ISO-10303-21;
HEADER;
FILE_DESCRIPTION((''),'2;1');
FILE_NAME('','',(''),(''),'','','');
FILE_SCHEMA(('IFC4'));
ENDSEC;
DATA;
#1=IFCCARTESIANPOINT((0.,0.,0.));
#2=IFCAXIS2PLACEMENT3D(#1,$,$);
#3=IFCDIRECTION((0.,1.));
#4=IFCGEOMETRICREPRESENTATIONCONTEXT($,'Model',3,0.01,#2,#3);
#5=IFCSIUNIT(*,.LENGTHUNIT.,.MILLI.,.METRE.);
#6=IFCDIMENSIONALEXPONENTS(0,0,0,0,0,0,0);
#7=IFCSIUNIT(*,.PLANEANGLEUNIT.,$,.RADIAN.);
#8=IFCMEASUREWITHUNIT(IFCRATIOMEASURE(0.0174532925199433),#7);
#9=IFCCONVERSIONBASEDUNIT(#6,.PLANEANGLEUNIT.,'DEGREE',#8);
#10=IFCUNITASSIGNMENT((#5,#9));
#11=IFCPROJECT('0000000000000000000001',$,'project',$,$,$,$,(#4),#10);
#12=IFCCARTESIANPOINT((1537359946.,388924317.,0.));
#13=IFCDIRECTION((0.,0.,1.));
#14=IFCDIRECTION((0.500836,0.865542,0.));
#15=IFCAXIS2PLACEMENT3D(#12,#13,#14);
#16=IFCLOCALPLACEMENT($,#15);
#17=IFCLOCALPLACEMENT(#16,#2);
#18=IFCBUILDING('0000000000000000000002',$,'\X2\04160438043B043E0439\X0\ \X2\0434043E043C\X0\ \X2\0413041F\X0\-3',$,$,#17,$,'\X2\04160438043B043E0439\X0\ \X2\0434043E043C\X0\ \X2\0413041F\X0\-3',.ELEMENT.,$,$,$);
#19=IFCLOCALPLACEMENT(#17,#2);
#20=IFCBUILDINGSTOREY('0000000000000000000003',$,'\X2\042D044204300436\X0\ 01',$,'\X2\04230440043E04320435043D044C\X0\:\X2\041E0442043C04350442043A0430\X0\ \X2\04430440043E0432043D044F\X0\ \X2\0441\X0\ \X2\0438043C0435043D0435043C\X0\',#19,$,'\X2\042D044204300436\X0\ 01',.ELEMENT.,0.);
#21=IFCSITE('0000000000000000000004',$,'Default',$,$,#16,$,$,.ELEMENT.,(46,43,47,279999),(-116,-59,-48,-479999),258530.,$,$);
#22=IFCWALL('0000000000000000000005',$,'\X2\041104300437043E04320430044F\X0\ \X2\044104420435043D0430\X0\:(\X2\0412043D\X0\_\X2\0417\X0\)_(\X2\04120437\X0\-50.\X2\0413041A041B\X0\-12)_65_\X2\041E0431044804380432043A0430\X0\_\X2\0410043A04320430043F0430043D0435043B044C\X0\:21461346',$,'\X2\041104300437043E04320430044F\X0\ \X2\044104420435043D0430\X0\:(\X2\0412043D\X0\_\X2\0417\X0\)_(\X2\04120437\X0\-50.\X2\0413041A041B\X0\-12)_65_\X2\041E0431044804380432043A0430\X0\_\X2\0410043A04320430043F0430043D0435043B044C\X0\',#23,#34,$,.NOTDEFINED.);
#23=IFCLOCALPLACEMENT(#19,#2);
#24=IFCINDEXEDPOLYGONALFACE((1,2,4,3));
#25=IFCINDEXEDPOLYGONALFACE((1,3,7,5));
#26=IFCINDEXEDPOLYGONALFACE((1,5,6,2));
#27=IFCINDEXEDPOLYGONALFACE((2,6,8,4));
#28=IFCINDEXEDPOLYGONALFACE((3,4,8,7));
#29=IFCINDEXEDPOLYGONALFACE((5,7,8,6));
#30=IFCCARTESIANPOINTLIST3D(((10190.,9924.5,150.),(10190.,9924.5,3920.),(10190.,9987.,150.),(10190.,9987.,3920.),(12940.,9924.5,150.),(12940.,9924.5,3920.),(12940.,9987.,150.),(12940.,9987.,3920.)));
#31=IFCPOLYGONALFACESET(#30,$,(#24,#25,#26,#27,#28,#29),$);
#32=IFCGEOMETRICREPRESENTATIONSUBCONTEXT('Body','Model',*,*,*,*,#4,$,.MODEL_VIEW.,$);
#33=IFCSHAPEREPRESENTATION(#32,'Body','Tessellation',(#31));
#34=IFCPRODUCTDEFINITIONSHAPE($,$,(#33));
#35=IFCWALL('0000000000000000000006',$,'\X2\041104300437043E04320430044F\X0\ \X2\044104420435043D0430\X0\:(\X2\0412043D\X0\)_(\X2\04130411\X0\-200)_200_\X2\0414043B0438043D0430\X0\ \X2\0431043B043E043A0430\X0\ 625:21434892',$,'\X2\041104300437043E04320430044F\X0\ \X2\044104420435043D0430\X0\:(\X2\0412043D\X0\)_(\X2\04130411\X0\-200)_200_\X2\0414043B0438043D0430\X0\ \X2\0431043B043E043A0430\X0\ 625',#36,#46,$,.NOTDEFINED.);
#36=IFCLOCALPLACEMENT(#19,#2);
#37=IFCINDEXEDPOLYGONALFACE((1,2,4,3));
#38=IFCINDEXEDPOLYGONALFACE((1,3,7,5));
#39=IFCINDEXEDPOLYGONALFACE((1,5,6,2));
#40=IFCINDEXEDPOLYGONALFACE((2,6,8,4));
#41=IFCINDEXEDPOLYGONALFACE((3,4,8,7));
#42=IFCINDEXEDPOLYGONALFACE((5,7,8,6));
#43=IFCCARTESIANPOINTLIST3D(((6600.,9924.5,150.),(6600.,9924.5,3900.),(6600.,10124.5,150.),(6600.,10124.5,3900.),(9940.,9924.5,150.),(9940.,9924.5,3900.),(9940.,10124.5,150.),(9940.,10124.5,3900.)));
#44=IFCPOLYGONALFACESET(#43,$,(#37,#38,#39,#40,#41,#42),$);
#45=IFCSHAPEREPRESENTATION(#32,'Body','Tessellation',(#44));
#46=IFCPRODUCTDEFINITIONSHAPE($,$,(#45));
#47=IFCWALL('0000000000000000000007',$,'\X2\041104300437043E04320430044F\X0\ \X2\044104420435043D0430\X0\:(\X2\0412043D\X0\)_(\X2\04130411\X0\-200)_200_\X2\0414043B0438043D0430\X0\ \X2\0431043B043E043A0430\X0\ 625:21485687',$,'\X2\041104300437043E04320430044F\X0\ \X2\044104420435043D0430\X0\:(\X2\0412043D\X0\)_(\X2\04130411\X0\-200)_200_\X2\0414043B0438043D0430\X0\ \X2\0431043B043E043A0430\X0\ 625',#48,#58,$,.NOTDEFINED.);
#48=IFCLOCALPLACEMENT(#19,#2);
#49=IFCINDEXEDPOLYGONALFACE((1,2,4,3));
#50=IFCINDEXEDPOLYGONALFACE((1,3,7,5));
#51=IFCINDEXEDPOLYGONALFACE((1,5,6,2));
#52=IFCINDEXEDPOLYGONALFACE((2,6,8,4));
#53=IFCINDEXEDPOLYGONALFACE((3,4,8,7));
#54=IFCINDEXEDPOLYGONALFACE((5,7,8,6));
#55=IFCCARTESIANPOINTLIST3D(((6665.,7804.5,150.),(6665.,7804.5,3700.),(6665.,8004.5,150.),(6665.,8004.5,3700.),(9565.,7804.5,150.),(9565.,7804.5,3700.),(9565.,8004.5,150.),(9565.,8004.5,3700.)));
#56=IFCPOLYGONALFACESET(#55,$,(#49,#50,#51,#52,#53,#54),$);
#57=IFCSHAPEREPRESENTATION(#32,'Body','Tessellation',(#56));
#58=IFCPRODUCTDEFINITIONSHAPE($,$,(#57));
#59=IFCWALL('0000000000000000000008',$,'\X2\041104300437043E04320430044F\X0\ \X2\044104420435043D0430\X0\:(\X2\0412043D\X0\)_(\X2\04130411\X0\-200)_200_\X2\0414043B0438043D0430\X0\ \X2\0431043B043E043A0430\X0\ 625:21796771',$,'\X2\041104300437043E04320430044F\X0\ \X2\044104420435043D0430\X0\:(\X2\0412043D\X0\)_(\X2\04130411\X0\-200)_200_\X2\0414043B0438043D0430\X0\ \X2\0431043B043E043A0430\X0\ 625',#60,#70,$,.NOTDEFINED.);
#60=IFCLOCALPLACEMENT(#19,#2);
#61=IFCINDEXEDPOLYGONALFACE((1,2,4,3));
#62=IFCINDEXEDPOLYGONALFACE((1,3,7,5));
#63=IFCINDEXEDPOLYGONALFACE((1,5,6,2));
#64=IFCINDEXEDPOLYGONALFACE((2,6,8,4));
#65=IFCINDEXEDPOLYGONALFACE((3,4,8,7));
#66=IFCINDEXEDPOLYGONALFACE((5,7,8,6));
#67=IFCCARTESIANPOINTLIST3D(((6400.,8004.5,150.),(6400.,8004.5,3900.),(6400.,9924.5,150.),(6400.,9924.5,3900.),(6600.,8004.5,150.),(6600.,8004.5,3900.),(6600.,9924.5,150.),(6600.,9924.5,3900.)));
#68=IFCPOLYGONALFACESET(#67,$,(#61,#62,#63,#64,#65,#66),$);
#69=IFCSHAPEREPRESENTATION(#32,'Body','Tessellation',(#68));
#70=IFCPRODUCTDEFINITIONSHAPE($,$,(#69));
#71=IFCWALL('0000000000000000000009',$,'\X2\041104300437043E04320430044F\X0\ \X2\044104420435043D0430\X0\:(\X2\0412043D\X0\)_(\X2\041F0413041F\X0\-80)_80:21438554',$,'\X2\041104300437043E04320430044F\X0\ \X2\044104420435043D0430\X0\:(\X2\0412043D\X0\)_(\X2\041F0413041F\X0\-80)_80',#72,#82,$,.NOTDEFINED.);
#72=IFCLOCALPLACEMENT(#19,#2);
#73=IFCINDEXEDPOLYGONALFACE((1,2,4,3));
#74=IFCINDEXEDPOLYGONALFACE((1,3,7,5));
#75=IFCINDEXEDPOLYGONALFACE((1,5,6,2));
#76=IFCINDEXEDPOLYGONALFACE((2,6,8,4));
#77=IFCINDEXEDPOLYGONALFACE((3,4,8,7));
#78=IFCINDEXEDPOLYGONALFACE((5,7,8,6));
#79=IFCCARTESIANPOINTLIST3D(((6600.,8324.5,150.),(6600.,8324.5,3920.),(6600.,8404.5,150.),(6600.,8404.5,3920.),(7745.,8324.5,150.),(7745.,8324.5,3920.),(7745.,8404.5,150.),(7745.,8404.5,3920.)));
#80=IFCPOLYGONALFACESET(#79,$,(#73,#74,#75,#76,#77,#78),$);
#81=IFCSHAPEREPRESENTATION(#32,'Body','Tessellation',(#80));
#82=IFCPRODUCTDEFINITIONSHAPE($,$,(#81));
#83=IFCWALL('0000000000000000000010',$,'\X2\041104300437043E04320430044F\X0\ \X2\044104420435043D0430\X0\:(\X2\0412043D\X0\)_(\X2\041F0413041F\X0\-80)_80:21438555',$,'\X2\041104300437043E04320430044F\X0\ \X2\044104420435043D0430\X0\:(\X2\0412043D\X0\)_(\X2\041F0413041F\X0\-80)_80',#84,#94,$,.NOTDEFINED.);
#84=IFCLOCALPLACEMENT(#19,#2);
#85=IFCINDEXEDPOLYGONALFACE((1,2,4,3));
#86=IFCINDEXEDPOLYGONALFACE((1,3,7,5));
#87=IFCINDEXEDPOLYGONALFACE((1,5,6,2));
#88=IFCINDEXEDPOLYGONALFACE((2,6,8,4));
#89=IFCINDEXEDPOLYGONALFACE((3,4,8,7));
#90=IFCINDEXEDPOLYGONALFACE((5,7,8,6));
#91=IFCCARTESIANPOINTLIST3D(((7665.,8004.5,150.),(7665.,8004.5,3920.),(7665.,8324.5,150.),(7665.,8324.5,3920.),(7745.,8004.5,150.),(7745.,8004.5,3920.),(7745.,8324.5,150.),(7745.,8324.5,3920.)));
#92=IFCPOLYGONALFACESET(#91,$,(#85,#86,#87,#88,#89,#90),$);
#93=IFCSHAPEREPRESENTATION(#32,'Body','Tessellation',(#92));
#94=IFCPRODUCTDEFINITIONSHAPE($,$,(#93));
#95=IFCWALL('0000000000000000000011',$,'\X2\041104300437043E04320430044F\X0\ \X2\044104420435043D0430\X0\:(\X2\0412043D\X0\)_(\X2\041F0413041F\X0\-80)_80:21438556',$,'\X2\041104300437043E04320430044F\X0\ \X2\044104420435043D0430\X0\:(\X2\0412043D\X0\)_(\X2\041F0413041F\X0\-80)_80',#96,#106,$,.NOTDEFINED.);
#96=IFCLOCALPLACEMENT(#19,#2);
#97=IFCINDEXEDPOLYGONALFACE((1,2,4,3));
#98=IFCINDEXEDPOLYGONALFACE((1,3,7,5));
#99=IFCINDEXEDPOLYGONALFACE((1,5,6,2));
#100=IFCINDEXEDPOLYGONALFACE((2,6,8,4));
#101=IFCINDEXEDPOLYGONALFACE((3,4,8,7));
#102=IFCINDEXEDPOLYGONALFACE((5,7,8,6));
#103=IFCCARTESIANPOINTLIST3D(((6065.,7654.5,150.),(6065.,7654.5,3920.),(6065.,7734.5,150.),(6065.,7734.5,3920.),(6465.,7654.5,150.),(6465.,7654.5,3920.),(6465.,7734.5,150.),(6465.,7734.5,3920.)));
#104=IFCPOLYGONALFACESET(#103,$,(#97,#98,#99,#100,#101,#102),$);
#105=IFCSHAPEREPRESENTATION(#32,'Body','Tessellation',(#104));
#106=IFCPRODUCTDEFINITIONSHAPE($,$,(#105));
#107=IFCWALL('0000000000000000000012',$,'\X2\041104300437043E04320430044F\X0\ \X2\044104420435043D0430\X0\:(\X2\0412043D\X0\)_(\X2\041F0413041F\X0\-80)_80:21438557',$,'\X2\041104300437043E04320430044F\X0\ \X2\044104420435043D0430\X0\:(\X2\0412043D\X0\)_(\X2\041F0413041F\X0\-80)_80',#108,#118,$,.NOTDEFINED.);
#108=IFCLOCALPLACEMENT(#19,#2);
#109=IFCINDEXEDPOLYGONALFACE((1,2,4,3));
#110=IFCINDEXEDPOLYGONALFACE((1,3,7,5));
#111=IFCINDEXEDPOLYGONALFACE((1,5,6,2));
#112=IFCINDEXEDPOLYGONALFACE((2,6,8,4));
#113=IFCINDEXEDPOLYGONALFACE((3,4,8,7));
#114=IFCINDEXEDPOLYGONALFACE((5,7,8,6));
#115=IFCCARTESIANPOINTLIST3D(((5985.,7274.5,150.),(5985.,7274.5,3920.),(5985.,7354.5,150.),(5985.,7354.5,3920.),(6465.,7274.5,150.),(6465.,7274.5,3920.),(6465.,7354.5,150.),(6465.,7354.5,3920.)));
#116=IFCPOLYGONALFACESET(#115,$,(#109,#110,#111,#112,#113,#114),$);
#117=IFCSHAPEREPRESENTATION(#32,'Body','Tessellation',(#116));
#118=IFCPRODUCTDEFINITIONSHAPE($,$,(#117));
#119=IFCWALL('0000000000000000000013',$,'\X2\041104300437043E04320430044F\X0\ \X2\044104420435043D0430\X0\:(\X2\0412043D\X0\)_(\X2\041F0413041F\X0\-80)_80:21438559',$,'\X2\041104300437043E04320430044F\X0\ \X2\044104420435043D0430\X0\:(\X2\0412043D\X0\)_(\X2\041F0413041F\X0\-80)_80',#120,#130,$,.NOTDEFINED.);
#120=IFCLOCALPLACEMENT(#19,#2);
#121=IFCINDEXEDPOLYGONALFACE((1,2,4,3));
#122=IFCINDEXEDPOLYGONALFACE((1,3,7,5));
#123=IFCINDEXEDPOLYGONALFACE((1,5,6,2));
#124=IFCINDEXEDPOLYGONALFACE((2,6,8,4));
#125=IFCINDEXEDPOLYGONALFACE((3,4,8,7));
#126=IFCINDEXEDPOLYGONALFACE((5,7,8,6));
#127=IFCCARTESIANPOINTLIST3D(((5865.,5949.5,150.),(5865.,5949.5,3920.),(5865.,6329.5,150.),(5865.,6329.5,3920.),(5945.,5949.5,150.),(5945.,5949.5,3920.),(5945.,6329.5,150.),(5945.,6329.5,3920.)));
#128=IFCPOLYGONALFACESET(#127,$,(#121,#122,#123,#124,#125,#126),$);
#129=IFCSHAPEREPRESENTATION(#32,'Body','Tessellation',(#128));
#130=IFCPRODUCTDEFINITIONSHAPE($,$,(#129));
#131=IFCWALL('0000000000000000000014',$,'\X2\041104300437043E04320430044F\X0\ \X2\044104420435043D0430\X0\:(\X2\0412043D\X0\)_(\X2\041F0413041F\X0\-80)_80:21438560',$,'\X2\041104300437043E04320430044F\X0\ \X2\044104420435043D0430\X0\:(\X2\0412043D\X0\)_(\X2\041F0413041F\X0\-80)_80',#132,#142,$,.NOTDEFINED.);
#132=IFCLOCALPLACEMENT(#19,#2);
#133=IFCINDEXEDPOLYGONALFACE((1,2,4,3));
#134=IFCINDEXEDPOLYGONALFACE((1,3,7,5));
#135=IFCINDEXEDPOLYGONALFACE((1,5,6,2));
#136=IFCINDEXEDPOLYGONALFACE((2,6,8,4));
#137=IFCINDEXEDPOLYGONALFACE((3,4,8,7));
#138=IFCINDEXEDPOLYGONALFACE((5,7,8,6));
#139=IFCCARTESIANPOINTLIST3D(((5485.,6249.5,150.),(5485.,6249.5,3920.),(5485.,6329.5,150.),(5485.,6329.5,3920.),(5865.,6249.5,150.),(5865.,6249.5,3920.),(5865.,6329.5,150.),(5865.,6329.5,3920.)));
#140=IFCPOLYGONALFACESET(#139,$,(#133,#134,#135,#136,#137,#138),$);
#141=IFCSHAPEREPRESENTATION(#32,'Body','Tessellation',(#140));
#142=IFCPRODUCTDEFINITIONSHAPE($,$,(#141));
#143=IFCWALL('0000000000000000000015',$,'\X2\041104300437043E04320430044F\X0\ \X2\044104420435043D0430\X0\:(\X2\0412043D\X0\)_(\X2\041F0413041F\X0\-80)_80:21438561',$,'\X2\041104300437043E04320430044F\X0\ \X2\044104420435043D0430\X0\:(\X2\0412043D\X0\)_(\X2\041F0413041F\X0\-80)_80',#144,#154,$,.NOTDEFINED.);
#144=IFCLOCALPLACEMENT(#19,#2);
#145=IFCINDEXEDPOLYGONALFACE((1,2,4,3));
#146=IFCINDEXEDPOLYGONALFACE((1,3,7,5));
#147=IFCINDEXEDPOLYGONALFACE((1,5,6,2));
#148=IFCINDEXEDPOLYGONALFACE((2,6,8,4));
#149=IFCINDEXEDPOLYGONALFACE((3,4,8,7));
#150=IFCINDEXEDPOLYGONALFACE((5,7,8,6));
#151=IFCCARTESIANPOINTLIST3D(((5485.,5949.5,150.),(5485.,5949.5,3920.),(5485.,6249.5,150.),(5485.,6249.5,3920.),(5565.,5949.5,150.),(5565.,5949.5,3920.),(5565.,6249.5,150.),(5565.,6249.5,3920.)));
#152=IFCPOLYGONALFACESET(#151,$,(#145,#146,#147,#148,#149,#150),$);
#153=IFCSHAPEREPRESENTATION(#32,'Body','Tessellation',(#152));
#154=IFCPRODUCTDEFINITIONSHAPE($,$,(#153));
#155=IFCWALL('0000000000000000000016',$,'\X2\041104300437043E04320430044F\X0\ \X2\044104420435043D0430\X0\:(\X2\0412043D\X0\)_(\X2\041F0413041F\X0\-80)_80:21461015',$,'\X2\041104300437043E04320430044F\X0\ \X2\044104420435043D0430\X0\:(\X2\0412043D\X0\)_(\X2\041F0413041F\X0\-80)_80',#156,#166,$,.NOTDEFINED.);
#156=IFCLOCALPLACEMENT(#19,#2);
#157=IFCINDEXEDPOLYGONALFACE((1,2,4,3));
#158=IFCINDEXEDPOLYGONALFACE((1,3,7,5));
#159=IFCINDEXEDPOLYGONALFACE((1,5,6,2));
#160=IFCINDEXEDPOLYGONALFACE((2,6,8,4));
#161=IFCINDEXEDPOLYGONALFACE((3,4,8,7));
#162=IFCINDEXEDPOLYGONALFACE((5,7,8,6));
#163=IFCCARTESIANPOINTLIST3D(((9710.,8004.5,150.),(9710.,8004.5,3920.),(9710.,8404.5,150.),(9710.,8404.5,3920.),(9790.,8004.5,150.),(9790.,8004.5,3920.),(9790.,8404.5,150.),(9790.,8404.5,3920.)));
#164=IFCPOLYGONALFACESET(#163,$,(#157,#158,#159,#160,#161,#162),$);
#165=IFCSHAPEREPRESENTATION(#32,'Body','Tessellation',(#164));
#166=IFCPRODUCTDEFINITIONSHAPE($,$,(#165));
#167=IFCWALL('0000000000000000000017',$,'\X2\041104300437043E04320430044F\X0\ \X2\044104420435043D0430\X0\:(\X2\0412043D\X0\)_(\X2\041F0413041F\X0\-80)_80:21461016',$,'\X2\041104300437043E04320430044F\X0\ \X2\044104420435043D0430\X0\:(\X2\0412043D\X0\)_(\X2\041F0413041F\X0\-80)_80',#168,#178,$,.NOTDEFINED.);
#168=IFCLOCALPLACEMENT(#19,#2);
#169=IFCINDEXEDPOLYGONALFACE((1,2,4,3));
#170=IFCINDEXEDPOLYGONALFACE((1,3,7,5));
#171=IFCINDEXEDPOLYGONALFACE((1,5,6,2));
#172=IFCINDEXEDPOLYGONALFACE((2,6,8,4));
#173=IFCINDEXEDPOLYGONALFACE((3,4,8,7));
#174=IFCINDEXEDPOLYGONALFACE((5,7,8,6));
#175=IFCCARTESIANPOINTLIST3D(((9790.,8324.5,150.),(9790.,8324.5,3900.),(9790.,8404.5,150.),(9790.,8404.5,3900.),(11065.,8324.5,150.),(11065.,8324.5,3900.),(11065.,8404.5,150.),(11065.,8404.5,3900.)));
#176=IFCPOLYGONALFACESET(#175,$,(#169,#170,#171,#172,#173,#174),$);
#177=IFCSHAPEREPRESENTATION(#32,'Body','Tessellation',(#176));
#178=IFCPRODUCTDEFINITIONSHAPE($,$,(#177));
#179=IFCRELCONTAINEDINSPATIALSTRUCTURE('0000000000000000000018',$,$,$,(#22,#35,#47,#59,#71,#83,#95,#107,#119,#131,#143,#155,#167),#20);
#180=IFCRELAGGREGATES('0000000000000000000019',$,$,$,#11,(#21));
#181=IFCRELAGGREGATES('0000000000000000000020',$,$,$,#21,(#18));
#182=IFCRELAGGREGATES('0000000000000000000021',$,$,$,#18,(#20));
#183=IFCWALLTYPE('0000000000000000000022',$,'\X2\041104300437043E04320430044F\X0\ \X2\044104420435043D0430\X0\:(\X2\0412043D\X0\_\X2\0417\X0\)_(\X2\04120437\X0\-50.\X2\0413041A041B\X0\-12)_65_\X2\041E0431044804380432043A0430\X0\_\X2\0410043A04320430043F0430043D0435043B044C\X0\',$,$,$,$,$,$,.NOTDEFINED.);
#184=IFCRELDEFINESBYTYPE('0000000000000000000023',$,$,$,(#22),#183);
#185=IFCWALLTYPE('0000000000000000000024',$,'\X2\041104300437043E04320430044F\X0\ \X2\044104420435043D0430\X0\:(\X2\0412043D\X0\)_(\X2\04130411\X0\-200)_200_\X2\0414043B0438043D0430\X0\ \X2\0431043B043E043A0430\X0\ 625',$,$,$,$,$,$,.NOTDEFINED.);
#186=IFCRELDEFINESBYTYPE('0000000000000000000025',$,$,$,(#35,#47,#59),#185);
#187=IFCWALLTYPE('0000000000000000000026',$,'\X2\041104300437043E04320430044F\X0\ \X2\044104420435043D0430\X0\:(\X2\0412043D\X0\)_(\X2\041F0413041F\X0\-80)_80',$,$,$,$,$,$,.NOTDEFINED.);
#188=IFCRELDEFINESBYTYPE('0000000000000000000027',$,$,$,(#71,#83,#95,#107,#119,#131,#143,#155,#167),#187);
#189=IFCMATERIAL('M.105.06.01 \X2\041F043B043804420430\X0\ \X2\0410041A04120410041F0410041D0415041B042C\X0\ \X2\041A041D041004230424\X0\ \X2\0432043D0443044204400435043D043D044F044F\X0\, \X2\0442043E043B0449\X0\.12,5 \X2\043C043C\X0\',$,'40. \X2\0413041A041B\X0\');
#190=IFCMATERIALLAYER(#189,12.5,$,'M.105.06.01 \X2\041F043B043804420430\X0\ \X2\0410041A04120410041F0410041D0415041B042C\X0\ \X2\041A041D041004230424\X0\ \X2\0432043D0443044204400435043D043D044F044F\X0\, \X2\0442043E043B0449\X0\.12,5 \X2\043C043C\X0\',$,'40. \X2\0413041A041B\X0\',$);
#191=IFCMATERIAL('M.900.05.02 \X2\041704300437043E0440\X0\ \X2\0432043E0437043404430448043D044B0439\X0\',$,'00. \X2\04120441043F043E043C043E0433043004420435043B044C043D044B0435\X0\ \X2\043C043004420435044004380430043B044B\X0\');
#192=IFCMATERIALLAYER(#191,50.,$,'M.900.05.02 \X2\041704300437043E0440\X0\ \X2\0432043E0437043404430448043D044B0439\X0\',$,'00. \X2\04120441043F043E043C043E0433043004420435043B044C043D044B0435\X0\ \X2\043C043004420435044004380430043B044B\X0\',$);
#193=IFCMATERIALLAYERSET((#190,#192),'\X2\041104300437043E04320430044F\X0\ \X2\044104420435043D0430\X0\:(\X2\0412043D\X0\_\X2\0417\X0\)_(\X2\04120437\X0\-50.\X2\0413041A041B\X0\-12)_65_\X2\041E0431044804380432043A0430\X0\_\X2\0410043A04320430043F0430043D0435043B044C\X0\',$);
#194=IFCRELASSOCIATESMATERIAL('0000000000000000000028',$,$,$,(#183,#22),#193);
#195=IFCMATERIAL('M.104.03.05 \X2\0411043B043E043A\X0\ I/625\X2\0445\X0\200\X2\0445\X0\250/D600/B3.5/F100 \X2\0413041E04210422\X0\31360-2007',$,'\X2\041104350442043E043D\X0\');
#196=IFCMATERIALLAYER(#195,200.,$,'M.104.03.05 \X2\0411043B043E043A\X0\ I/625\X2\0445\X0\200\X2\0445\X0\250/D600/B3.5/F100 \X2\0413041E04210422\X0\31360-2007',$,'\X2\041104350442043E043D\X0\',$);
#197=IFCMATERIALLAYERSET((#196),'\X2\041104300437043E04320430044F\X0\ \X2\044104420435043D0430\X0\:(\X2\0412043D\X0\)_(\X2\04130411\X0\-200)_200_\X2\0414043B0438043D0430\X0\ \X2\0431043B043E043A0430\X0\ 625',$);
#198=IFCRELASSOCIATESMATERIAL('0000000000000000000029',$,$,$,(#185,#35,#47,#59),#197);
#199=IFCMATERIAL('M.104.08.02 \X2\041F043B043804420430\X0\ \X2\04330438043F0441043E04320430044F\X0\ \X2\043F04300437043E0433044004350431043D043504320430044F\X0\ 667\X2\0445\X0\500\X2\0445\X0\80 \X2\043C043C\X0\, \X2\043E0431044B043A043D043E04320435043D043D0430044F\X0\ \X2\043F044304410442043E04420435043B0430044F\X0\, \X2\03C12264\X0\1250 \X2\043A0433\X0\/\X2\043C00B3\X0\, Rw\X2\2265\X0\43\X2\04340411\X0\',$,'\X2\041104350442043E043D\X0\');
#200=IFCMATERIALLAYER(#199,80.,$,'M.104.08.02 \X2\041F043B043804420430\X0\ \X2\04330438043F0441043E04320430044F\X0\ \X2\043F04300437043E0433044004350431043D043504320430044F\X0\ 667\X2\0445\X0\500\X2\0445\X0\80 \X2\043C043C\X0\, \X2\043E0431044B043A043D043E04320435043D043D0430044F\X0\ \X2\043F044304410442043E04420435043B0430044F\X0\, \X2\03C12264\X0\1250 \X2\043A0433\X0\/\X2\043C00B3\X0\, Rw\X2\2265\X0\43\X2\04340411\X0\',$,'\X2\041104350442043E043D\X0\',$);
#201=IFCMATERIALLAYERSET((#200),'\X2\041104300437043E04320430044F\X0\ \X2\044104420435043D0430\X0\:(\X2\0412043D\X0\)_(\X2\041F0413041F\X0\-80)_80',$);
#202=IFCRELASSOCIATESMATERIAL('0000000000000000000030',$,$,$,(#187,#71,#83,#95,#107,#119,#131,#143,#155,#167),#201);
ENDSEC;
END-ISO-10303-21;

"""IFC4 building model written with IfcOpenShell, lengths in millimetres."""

from ifc_helpers import new_model, entity, si_unit, converted_unit, direction, frame, frame_2d, origin, place, context, subcontext, project, spatial, rectangle, extrude, material, layer, layer_set, layer_usage, type_object, element, save


model = new_model("IFC4")

# Units and contexts
model_context = context("Model", 3, precision=0.01, world=origin(), true_north=direction((0.0, 1.0)))
body_context = subcontext(model_context, "Body", "Model", "MODEL_VIEW")
ifc_project = project(units=[si_unit("LENGTHUNIT", "METRE", prefix="MILLI"), converted_unit("PLANEANGLEUNIT", "DEGREE", entity("IfcRatioMeasure", 0.0174532925199433), si_unit("PLANEANGLEUNIT", "RADIAN"), dimensions=[0, 0, 0, 0, 0, 0, 0])], contexts=[model_context])

# Site, building, storey
site_placement = place(None, frame((1537359946.0, 388924317.0, 0.0), z_axis=(0.0, 0.0, 1.0), x_axis=(0.500836, 0.865542, 0.0)))
site = spatial("IfcSite", under=ifc_project, at=site_placement, Name="Default", CompositionType="ELEMENT", RefLatitude=(46, 43, 47, 279999), RefLongitude=(-116, -59, -48, -479999), RefElevation=258530.0)
building_placement = place(site_placement, origin())
building = spatial("IfcBuilding", under=site, at=building_placement, Name="Жилой дом ГП-3", LongName="Жилой дом ГП-3", CompositionType="ELEMENT")
storey_placement = place(building_placement, origin())
storey = spatial("IfcBuildingStorey", under=building, at=storey_placement, Name="Этаж 01", ObjectType="Уровень:Отметка уровня с именем", LongName="Этаж 01", CompositionType="ELEMENT", Elevation=0.0)

# Walls
ifc_material_1 = material(Name="M.105.06.01 Плита АКВАПАНЕЛЬ КНАУФ внутренняя, толщ.12,5 мм", Category="40. ГКЛ")
ifc_layer_1 = layer(ifc_material_1, 12.5, Name="M.105.06.01 Плита АКВАПАНЕЛЬ КНАУФ внутренняя, толщ.12,5 мм", Category="40. ГКЛ")
ifc_material_2 = material(Name="M.900.05.02 Зазор воздушный", Category="00. Вспомогательные материалы")
ifc_layer_2 = layer(ifc_material_2, 50.0, Name="M.900.05.02 Зазор воздушный", Category="00. Вспомогательные материалы")
ifc_layer_set_1 = layer_set([ifc_layer_1, ifc_layer_2], Name="Базовая стена:(Вн_З)_(Вз-50.ГКЛ-12)_65_Обшивка_Аквапанель")
ifc_layer_usage_1 = layer_usage(ifc_layer_set_1, "AXIS2", "POSITIVE", -31.2)
wall_type_1 = type_object("IfcWallType", Name="Базовая стена:(Вн_З)_(Вз-50.ГКЛ-12)_65_Обшивка_Аквапанель", PredefinedType="NOTDEFINED", material=ifc_layer_set_1)
wall_1_placement = place(storey_placement, frame((10190.0, 9955.8, 150.0)))
element("IfcWall", 1, at=wall_1_placement, inside=storey, type_object=wall_type_1, material=ifc_layer_usage_1, Name="Базовая стена:(Вн_З)_(Вз-50.ГКЛ-12)_65_Обшивка_Аквапанель:21461346", ObjectType="Базовая стена:(Вн_З)_(Вз-50.ГКЛ-12)_65_Обшивка_Аквапанель", PredefinedType="NOTDEFINED", context=body_context, shape_type="SweptSolid", body=[
    extrude(rectangle(XDim=2750.0, YDim=62.5, at=frame_2d((1375.0, 0.0), x_axis=(-1.0, 0.0))), origin(), (0.0, 0.0, 1.0), 3770.0),
])
ifc_material_3 = material(Name="M.104.03.05 Блок I/625х200х250/D600/B3.5/F100 ГОСТ31360-2007", Category="Бетон")
ifc_layer_3 = layer(ifc_material_3, 200.0, Name="M.104.03.05 Блок I/625х200х250/D600/B3.5/F100 ГОСТ31360-2007", Category="Бетон")
ifc_layer_set_2 = layer_set([ifc_layer_3], Name="Базовая стена:(Вн)_(ГБ-200)_200_Длина блока 625")
ifc_layer_usage_2 = layer_usage(ifc_layer_set_2, "AXIS2", "NEGATIVE", 100.0)
wall_type_2 = type_object("IfcWallType", Name="Базовая стена:(Вн)_(ГБ-200)_200_Длина блока 625", PredefinedType="NOTDEFINED", material=ifc_layer_set_2)
wall_2_placement = place(storey_placement, frame((9940.0, 10024.5, 150.0), z_axis=(0.0, 0.0, 1.0), x_axis=(-1.0, 0.0, 0.0)))
element("IfcWall", 2, at=wall_2_placement, inside=storey, type_object=wall_type_2, material=ifc_layer_usage_2, Name="Базовая стена:(Вн)_(ГБ-200)_200_Длина блока 625:21434892", ObjectType="Базовая стена:(Вн)_(ГБ-200)_200_Длина блока 625", PredefinedType="NOTDEFINED", context=body_context, shape_type="SweptSolid", body=[
    extrude(rectangle(XDim=3340.0, YDim=200.0, at=frame_2d((1670.0, 0.0), x_axis=(-1.0, 0.0))), origin(), (0.0, 0.0, 1.0), 3750.0),
])
ifc_layer_usage_3 = layer_usage(ifc_layer_set_2, "AXIS2", "NEGATIVE", 100.0)
wall_3_placement = place(storey_placement, frame((9565.0, 7904.5, 150.0), z_axis=(0.0, 0.0, 1.0), x_axis=(-1.0, 0.0, 0.0)))
element("IfcWall", 3, at=wall_3_placement, inside=storey, type_object=wall_type_2, material=ifc_layer_usage_3, Name="Базовая стена:(Вн)_(ГБ-200)_200_Длина блока 625:21485687", ObjectType="Базовая стена:(Вн)_(ГБ-200)_200_Длина блока 625", PredefinedType="NOTDEFINED", context=body_context, shape_type="SweptSolid", body=[
    extrude(rectangle(XDim=2900.0, YDim=200.0, at=frame_2d((1450.0, 0.0), x_axis=(-1.0, 0.0))), origin(), (0.0, 0.0, 1.0), 3550.0),
])
ifc_layer_usage_4 = layer_usage(ifc_layer_set_2, "AXIS2", "NEGATIVE", 100.0)
wall_4_placement = place(storey_placement, frame((6500.0, 8004.5, 150.0), z_axis=(0.0, 0.0, 1.0), x_axis=(0.0, 1.0, 0.0)))
element("IfcWall", 4, at=wall_4_placement, inside=storey, type_object=wall_type_2, material=ifc_layer_usage_4, Name="Базовая стена:(Вн)_(ГБ-200)_200_Длина блока 625:21796771", ObjectType="Базовая стена:(Вн)_(ГБ-200)_200_Длина блока 625", PredefinedType="NOTDEFINED", context=body_context, shape_type="SweptSolid", body=[
    extrude(rectangle(XDim=1920.0, YDim=200.0, at=frame_2d((960.0, 0.0), x_axis=(-1.0, 0.0))), origin(), (0.0, 0.0, 1.0), 3750.0),
])
ifc_material_4 = material(Name="M.104.08.02 Плита гипсовая пазогребневая 667х500х80 мм, обыкновенная пустотелая, ρ≤1250 кг/м³, Rw≥43дБ", Category="Бетон")
ifc_layer_4 = layer(ifc_material_4, 80.0, Name="M.104.08.02 Плита гипсовая пазогребневая 667х500х80 мм, обыкновенная пустотелая, ρ≤1250 кг/м³, Rw≥43дБ", Category="Бетон")
ifc_layer_set_3 = layer_set([ifc_layer_4], Name="Базовая стена:(Вн)_(ПГП-80)_80")
ifc_layer_usage_5 = layer_usage(ifc_layer_set_3, "AXIS2", "POSITIVE", -40.0)
wall_type_3 = type_object("IfcWallType", Name="Базовая стена:(Вн)_(ПГП-80)_80", PredefinedType="NOTDEFINED", material=ifc_layer_set_3)
wall_5_placement = place(storey_placement, frame((6600.0, 8364.5, 150.0)))
element("IfcWall", 5, at=wall_5_placement, inside=storey, type_object=wall_type_3, material=ifc_layer_usage_5, Name="Базовая стена:(Вн)_(ПГП-80)_80:21438554", ObjectType="Базовая стена:(Вн)_(ПГП-80)_80", PredefinedType="NOTDEFINED", context=body_context, shape_type="SweptSolid", body=[
    extrude(rectangle(XDim=1145.0, YDim=80.0, at=frame_2d((572.5, 0.0), x_axis=(-1.0, 0.0))), origin(), (0.0, 0.0, 1.0), 3770.0),
])
ifc_layer_usage_6 = layer_usage(ifc_layer_set_3, "AXIS2", "POSITIVE", -40.0)
wall_6_placement = place(storey_placement, frame((7705.0, 8324.5, 150.0), z_axis=(0.0, 0.0, 1.0), x_axis=(0.0, -1.0, 0.0)))
element("IfcWall", 6, at=wall_6_placement, inside=storey, type_object=wall_type_3, material=ifc_layer_usage_6, Name="Базовая стена:(Вн)_(ПГП-80)_80:21438555", ObjectType="Базовая стена:(Вн)_(ПГП-80)_80", PredefinedType="NOTDEFINED", context=body_context, shape_type="SweptSolid", body=[
    extrude(rectangle(XDim=320.0, YDim=80.0, at=frame_2d((160.0, 0.0), x_axis=(-1.0, 0.0))), origin(), (0.0, 0.0, 1.0), 3770.0),
])
ifc_layer_usage_7 = layer_usage(ifc_layer_set_3, "AXIS2", "POSITIVE", -40.0)
wall_7_placement = place(storey_placement, frame((6065.0, 7694.5, 150.0)))
element("IfcWall", 7, at=wall_7_placement, inside=storey, type_object=wall_type_3, material=ifc_layer_usage_7, Name="Базовая стена:(Вн)_(ПГП-80)_80:21438556", ObjectType="Базовая стена:(Вн)_(ПГП-80)_80", PredefinedType="NOTDEFINED", context=body_context, shape_type="SweptSolid", body=[
    extrude(rectangle(XDim=400.0, YDim=80.0, at=frame_2d((200.0, 0.0), x_axis=(-1.0, 0.0))), origin(), (0.0, 0.0, 1.0), 3770.0),
])
ifc_layer_usage_8 = layer_usage(ifc_layer_set_3, "AXIS2", "NEGATIVE", 40.0)
wall_8_placement = place(storey_placement, frame((5985.0, 7314.5, 150.0)))
element("IfcWall", 8, at=wall_8_placement, inside=storey, type_object=wall_type_3, material=ifc_layer_usage_8, Name="Базовая стена:(Вн)_(ПГП-80)_80:21438557", ObjectType="Базовая стена:(Вн)_(ПГП-80)_80", PredefinedType="NOTDEFINED", context=body_context, shape_type="SweptSolid", body=[
    extrude(rectangle(XDim=480.0, YDim=80.0, at=frame_2d((240.0, 0.0), x_axis=(-1.0, 0.0))), origin(), (0.0, 0.0, 1.0), 3770.0),
])
ifc_layer_usage_9 = layer_usage(ifc_layer_set_3, "AXIS2", "NEGATIVE", 40.0)
wall_9_placement = place(storey_placement, frame((5905.0, 5949.5, 150.0), z_axis=(0.0, 0.0, 1.0), x_axis=(0.0, 1.0, 0.0)))
element("IfcWall", 9, at=wall_9_placement, inside=storey, type_object=wall_type_3, material=ifc_layer_usage_9, Name="Базовая стена:(Вн)_(ПГП-80)_80:21438559", ObjectType="Базовая стена:(Вн)_(ПГП-80)_80", PredefinedType="NOTDEFINED", context=body_context, shape_type="SweptSolid", body=[
    extrude(rectangle(XDim=380.0, YDim=80.0, at=frame_2d((190.0, 0.0), x_axis=(-1.0, 0.0))), origin(), (0.0, 0.0, 1.0), 3770.0),
])
ifc_layer_usage_10 = layer_usage(ifc_layer_set_3, "AXIS2", "NEGATIVE", 40.0)
wall_10_placement = place(storey_placement, frame((5865.0, 6289.5, 150.0), z_axis=(0.0, 0.0, 1.0), x_axis=(-1.0, 0.0, 0.0)))
element("IfcWall", 10, at=wall_10_placement, inside=storey, type_object=wall_type_3, material=ifc_layer_usage_10, Name="Базовая стена:(Вн)_(ПГП-80)_80:21438560", ObjectType="Базовая стена:(Вн)_(ПГП-80)_80", PredefinedType="NOTDEFINED", context=body_context, shape_type="SweptSolid", body=[
    extrude(rectangle(XDim=380.0, YDim=80.0, at=frame_2d((190.0, 0.0), x_axis=(-1.0, 0.0))), origin(), (0.0, 0.0, 1.0), 3770.0),
])
ifc_layer_usage_11 = layer_usage(ifc_layer_set_3, "AXIS2", "NEGATIVE", 40.0)
wall_11_placement = place(storey_placement, frame((5525.0, 6249.5, 150.0), z_axis=(0.0, 0.0, 1.0), x_axis=(0.0, -1.0, 0.0)))
element("IfcWall", 11, at=wall_11_placement, inside=storey, type_object=wall_type_3, material=ifc_layer_usage_11, Name="Базовая стена:(Вн)_(ПГП-80)_80:21438561", ObjectType="Базовая стена:(Вн)_(ПГП-80)_80", PredefinedType="NOTDEFINED", context=body_context, shape_type="SweptSolid", body=[
    extrude(rectangle(XDim=300.0, YDim=80.0, at=frame_2d((150.0, 0.0), x_axis=(-1.0, 0.0))), origin(), (0.0, 0.0, 1.0), 3770.0),
])
ifc_layer_usage_12 = layer_usage(ifc_layer_set_3, "AXIS2", "NEGATIVE", 40.0)
wall_12_placement = place(storey_placement, frame((9750.0, 8004.5, 150.0), z_axis=(0.0, 0.0, 1.0), x_axis=(0.0, 1.0, 0.0)))
element("IfcWall", 12, at=wall_12_placement, inside=storey, type_object=wall_type_3, material=ifc_layer_usage_12, Name="Базовая стена:(Вн)_(ПГП-80)_80:21461015", ObjectType="Базовая стена:(Вн)_(ПГП-80)_80", PredefinedType="NOTDEFINED", context=body_context, shape_type="SweptSolid", body=[
    extrude(rectangle(XDim=400.0, YDim=80.0, at=frame_2d((200.0, 0.0), x_axis=(-1.0, 0.0))), origin(), (0.0, 0.0, 1.0), 3770.0),
])
ifc_layer_usage_13 = layer_usage(ifc_layer_set_3, "AXIS2", "NEGATIVE", 40.0)
wall_13_placement = place(storey_placement, frame((9790.0, 8364.5, 150.0)))
element("IfcWall", 13, at=wall_13_placement, inside=storey, type_object=wall_type_3, material=ifc_layer_usage_13, Name="Базовая стена:(Вн)_(ПГП-80)_80:21461016", ObjectType="Базовая стена:(Вн)_(ПГП-80)_80", PredefinedType="NOTDEFINED", context=body_context, shape_type="SweptSolid", body=[
    extrude(rectangle(XDim=1275.0, YDim=80.0, at=frame_2d((637.5, 0.0), x_axis=(-1.0, 0.0))), origin(), (0.0, 0.0, 1.0), 3750.0),
])

save(model, "model.ifc")
